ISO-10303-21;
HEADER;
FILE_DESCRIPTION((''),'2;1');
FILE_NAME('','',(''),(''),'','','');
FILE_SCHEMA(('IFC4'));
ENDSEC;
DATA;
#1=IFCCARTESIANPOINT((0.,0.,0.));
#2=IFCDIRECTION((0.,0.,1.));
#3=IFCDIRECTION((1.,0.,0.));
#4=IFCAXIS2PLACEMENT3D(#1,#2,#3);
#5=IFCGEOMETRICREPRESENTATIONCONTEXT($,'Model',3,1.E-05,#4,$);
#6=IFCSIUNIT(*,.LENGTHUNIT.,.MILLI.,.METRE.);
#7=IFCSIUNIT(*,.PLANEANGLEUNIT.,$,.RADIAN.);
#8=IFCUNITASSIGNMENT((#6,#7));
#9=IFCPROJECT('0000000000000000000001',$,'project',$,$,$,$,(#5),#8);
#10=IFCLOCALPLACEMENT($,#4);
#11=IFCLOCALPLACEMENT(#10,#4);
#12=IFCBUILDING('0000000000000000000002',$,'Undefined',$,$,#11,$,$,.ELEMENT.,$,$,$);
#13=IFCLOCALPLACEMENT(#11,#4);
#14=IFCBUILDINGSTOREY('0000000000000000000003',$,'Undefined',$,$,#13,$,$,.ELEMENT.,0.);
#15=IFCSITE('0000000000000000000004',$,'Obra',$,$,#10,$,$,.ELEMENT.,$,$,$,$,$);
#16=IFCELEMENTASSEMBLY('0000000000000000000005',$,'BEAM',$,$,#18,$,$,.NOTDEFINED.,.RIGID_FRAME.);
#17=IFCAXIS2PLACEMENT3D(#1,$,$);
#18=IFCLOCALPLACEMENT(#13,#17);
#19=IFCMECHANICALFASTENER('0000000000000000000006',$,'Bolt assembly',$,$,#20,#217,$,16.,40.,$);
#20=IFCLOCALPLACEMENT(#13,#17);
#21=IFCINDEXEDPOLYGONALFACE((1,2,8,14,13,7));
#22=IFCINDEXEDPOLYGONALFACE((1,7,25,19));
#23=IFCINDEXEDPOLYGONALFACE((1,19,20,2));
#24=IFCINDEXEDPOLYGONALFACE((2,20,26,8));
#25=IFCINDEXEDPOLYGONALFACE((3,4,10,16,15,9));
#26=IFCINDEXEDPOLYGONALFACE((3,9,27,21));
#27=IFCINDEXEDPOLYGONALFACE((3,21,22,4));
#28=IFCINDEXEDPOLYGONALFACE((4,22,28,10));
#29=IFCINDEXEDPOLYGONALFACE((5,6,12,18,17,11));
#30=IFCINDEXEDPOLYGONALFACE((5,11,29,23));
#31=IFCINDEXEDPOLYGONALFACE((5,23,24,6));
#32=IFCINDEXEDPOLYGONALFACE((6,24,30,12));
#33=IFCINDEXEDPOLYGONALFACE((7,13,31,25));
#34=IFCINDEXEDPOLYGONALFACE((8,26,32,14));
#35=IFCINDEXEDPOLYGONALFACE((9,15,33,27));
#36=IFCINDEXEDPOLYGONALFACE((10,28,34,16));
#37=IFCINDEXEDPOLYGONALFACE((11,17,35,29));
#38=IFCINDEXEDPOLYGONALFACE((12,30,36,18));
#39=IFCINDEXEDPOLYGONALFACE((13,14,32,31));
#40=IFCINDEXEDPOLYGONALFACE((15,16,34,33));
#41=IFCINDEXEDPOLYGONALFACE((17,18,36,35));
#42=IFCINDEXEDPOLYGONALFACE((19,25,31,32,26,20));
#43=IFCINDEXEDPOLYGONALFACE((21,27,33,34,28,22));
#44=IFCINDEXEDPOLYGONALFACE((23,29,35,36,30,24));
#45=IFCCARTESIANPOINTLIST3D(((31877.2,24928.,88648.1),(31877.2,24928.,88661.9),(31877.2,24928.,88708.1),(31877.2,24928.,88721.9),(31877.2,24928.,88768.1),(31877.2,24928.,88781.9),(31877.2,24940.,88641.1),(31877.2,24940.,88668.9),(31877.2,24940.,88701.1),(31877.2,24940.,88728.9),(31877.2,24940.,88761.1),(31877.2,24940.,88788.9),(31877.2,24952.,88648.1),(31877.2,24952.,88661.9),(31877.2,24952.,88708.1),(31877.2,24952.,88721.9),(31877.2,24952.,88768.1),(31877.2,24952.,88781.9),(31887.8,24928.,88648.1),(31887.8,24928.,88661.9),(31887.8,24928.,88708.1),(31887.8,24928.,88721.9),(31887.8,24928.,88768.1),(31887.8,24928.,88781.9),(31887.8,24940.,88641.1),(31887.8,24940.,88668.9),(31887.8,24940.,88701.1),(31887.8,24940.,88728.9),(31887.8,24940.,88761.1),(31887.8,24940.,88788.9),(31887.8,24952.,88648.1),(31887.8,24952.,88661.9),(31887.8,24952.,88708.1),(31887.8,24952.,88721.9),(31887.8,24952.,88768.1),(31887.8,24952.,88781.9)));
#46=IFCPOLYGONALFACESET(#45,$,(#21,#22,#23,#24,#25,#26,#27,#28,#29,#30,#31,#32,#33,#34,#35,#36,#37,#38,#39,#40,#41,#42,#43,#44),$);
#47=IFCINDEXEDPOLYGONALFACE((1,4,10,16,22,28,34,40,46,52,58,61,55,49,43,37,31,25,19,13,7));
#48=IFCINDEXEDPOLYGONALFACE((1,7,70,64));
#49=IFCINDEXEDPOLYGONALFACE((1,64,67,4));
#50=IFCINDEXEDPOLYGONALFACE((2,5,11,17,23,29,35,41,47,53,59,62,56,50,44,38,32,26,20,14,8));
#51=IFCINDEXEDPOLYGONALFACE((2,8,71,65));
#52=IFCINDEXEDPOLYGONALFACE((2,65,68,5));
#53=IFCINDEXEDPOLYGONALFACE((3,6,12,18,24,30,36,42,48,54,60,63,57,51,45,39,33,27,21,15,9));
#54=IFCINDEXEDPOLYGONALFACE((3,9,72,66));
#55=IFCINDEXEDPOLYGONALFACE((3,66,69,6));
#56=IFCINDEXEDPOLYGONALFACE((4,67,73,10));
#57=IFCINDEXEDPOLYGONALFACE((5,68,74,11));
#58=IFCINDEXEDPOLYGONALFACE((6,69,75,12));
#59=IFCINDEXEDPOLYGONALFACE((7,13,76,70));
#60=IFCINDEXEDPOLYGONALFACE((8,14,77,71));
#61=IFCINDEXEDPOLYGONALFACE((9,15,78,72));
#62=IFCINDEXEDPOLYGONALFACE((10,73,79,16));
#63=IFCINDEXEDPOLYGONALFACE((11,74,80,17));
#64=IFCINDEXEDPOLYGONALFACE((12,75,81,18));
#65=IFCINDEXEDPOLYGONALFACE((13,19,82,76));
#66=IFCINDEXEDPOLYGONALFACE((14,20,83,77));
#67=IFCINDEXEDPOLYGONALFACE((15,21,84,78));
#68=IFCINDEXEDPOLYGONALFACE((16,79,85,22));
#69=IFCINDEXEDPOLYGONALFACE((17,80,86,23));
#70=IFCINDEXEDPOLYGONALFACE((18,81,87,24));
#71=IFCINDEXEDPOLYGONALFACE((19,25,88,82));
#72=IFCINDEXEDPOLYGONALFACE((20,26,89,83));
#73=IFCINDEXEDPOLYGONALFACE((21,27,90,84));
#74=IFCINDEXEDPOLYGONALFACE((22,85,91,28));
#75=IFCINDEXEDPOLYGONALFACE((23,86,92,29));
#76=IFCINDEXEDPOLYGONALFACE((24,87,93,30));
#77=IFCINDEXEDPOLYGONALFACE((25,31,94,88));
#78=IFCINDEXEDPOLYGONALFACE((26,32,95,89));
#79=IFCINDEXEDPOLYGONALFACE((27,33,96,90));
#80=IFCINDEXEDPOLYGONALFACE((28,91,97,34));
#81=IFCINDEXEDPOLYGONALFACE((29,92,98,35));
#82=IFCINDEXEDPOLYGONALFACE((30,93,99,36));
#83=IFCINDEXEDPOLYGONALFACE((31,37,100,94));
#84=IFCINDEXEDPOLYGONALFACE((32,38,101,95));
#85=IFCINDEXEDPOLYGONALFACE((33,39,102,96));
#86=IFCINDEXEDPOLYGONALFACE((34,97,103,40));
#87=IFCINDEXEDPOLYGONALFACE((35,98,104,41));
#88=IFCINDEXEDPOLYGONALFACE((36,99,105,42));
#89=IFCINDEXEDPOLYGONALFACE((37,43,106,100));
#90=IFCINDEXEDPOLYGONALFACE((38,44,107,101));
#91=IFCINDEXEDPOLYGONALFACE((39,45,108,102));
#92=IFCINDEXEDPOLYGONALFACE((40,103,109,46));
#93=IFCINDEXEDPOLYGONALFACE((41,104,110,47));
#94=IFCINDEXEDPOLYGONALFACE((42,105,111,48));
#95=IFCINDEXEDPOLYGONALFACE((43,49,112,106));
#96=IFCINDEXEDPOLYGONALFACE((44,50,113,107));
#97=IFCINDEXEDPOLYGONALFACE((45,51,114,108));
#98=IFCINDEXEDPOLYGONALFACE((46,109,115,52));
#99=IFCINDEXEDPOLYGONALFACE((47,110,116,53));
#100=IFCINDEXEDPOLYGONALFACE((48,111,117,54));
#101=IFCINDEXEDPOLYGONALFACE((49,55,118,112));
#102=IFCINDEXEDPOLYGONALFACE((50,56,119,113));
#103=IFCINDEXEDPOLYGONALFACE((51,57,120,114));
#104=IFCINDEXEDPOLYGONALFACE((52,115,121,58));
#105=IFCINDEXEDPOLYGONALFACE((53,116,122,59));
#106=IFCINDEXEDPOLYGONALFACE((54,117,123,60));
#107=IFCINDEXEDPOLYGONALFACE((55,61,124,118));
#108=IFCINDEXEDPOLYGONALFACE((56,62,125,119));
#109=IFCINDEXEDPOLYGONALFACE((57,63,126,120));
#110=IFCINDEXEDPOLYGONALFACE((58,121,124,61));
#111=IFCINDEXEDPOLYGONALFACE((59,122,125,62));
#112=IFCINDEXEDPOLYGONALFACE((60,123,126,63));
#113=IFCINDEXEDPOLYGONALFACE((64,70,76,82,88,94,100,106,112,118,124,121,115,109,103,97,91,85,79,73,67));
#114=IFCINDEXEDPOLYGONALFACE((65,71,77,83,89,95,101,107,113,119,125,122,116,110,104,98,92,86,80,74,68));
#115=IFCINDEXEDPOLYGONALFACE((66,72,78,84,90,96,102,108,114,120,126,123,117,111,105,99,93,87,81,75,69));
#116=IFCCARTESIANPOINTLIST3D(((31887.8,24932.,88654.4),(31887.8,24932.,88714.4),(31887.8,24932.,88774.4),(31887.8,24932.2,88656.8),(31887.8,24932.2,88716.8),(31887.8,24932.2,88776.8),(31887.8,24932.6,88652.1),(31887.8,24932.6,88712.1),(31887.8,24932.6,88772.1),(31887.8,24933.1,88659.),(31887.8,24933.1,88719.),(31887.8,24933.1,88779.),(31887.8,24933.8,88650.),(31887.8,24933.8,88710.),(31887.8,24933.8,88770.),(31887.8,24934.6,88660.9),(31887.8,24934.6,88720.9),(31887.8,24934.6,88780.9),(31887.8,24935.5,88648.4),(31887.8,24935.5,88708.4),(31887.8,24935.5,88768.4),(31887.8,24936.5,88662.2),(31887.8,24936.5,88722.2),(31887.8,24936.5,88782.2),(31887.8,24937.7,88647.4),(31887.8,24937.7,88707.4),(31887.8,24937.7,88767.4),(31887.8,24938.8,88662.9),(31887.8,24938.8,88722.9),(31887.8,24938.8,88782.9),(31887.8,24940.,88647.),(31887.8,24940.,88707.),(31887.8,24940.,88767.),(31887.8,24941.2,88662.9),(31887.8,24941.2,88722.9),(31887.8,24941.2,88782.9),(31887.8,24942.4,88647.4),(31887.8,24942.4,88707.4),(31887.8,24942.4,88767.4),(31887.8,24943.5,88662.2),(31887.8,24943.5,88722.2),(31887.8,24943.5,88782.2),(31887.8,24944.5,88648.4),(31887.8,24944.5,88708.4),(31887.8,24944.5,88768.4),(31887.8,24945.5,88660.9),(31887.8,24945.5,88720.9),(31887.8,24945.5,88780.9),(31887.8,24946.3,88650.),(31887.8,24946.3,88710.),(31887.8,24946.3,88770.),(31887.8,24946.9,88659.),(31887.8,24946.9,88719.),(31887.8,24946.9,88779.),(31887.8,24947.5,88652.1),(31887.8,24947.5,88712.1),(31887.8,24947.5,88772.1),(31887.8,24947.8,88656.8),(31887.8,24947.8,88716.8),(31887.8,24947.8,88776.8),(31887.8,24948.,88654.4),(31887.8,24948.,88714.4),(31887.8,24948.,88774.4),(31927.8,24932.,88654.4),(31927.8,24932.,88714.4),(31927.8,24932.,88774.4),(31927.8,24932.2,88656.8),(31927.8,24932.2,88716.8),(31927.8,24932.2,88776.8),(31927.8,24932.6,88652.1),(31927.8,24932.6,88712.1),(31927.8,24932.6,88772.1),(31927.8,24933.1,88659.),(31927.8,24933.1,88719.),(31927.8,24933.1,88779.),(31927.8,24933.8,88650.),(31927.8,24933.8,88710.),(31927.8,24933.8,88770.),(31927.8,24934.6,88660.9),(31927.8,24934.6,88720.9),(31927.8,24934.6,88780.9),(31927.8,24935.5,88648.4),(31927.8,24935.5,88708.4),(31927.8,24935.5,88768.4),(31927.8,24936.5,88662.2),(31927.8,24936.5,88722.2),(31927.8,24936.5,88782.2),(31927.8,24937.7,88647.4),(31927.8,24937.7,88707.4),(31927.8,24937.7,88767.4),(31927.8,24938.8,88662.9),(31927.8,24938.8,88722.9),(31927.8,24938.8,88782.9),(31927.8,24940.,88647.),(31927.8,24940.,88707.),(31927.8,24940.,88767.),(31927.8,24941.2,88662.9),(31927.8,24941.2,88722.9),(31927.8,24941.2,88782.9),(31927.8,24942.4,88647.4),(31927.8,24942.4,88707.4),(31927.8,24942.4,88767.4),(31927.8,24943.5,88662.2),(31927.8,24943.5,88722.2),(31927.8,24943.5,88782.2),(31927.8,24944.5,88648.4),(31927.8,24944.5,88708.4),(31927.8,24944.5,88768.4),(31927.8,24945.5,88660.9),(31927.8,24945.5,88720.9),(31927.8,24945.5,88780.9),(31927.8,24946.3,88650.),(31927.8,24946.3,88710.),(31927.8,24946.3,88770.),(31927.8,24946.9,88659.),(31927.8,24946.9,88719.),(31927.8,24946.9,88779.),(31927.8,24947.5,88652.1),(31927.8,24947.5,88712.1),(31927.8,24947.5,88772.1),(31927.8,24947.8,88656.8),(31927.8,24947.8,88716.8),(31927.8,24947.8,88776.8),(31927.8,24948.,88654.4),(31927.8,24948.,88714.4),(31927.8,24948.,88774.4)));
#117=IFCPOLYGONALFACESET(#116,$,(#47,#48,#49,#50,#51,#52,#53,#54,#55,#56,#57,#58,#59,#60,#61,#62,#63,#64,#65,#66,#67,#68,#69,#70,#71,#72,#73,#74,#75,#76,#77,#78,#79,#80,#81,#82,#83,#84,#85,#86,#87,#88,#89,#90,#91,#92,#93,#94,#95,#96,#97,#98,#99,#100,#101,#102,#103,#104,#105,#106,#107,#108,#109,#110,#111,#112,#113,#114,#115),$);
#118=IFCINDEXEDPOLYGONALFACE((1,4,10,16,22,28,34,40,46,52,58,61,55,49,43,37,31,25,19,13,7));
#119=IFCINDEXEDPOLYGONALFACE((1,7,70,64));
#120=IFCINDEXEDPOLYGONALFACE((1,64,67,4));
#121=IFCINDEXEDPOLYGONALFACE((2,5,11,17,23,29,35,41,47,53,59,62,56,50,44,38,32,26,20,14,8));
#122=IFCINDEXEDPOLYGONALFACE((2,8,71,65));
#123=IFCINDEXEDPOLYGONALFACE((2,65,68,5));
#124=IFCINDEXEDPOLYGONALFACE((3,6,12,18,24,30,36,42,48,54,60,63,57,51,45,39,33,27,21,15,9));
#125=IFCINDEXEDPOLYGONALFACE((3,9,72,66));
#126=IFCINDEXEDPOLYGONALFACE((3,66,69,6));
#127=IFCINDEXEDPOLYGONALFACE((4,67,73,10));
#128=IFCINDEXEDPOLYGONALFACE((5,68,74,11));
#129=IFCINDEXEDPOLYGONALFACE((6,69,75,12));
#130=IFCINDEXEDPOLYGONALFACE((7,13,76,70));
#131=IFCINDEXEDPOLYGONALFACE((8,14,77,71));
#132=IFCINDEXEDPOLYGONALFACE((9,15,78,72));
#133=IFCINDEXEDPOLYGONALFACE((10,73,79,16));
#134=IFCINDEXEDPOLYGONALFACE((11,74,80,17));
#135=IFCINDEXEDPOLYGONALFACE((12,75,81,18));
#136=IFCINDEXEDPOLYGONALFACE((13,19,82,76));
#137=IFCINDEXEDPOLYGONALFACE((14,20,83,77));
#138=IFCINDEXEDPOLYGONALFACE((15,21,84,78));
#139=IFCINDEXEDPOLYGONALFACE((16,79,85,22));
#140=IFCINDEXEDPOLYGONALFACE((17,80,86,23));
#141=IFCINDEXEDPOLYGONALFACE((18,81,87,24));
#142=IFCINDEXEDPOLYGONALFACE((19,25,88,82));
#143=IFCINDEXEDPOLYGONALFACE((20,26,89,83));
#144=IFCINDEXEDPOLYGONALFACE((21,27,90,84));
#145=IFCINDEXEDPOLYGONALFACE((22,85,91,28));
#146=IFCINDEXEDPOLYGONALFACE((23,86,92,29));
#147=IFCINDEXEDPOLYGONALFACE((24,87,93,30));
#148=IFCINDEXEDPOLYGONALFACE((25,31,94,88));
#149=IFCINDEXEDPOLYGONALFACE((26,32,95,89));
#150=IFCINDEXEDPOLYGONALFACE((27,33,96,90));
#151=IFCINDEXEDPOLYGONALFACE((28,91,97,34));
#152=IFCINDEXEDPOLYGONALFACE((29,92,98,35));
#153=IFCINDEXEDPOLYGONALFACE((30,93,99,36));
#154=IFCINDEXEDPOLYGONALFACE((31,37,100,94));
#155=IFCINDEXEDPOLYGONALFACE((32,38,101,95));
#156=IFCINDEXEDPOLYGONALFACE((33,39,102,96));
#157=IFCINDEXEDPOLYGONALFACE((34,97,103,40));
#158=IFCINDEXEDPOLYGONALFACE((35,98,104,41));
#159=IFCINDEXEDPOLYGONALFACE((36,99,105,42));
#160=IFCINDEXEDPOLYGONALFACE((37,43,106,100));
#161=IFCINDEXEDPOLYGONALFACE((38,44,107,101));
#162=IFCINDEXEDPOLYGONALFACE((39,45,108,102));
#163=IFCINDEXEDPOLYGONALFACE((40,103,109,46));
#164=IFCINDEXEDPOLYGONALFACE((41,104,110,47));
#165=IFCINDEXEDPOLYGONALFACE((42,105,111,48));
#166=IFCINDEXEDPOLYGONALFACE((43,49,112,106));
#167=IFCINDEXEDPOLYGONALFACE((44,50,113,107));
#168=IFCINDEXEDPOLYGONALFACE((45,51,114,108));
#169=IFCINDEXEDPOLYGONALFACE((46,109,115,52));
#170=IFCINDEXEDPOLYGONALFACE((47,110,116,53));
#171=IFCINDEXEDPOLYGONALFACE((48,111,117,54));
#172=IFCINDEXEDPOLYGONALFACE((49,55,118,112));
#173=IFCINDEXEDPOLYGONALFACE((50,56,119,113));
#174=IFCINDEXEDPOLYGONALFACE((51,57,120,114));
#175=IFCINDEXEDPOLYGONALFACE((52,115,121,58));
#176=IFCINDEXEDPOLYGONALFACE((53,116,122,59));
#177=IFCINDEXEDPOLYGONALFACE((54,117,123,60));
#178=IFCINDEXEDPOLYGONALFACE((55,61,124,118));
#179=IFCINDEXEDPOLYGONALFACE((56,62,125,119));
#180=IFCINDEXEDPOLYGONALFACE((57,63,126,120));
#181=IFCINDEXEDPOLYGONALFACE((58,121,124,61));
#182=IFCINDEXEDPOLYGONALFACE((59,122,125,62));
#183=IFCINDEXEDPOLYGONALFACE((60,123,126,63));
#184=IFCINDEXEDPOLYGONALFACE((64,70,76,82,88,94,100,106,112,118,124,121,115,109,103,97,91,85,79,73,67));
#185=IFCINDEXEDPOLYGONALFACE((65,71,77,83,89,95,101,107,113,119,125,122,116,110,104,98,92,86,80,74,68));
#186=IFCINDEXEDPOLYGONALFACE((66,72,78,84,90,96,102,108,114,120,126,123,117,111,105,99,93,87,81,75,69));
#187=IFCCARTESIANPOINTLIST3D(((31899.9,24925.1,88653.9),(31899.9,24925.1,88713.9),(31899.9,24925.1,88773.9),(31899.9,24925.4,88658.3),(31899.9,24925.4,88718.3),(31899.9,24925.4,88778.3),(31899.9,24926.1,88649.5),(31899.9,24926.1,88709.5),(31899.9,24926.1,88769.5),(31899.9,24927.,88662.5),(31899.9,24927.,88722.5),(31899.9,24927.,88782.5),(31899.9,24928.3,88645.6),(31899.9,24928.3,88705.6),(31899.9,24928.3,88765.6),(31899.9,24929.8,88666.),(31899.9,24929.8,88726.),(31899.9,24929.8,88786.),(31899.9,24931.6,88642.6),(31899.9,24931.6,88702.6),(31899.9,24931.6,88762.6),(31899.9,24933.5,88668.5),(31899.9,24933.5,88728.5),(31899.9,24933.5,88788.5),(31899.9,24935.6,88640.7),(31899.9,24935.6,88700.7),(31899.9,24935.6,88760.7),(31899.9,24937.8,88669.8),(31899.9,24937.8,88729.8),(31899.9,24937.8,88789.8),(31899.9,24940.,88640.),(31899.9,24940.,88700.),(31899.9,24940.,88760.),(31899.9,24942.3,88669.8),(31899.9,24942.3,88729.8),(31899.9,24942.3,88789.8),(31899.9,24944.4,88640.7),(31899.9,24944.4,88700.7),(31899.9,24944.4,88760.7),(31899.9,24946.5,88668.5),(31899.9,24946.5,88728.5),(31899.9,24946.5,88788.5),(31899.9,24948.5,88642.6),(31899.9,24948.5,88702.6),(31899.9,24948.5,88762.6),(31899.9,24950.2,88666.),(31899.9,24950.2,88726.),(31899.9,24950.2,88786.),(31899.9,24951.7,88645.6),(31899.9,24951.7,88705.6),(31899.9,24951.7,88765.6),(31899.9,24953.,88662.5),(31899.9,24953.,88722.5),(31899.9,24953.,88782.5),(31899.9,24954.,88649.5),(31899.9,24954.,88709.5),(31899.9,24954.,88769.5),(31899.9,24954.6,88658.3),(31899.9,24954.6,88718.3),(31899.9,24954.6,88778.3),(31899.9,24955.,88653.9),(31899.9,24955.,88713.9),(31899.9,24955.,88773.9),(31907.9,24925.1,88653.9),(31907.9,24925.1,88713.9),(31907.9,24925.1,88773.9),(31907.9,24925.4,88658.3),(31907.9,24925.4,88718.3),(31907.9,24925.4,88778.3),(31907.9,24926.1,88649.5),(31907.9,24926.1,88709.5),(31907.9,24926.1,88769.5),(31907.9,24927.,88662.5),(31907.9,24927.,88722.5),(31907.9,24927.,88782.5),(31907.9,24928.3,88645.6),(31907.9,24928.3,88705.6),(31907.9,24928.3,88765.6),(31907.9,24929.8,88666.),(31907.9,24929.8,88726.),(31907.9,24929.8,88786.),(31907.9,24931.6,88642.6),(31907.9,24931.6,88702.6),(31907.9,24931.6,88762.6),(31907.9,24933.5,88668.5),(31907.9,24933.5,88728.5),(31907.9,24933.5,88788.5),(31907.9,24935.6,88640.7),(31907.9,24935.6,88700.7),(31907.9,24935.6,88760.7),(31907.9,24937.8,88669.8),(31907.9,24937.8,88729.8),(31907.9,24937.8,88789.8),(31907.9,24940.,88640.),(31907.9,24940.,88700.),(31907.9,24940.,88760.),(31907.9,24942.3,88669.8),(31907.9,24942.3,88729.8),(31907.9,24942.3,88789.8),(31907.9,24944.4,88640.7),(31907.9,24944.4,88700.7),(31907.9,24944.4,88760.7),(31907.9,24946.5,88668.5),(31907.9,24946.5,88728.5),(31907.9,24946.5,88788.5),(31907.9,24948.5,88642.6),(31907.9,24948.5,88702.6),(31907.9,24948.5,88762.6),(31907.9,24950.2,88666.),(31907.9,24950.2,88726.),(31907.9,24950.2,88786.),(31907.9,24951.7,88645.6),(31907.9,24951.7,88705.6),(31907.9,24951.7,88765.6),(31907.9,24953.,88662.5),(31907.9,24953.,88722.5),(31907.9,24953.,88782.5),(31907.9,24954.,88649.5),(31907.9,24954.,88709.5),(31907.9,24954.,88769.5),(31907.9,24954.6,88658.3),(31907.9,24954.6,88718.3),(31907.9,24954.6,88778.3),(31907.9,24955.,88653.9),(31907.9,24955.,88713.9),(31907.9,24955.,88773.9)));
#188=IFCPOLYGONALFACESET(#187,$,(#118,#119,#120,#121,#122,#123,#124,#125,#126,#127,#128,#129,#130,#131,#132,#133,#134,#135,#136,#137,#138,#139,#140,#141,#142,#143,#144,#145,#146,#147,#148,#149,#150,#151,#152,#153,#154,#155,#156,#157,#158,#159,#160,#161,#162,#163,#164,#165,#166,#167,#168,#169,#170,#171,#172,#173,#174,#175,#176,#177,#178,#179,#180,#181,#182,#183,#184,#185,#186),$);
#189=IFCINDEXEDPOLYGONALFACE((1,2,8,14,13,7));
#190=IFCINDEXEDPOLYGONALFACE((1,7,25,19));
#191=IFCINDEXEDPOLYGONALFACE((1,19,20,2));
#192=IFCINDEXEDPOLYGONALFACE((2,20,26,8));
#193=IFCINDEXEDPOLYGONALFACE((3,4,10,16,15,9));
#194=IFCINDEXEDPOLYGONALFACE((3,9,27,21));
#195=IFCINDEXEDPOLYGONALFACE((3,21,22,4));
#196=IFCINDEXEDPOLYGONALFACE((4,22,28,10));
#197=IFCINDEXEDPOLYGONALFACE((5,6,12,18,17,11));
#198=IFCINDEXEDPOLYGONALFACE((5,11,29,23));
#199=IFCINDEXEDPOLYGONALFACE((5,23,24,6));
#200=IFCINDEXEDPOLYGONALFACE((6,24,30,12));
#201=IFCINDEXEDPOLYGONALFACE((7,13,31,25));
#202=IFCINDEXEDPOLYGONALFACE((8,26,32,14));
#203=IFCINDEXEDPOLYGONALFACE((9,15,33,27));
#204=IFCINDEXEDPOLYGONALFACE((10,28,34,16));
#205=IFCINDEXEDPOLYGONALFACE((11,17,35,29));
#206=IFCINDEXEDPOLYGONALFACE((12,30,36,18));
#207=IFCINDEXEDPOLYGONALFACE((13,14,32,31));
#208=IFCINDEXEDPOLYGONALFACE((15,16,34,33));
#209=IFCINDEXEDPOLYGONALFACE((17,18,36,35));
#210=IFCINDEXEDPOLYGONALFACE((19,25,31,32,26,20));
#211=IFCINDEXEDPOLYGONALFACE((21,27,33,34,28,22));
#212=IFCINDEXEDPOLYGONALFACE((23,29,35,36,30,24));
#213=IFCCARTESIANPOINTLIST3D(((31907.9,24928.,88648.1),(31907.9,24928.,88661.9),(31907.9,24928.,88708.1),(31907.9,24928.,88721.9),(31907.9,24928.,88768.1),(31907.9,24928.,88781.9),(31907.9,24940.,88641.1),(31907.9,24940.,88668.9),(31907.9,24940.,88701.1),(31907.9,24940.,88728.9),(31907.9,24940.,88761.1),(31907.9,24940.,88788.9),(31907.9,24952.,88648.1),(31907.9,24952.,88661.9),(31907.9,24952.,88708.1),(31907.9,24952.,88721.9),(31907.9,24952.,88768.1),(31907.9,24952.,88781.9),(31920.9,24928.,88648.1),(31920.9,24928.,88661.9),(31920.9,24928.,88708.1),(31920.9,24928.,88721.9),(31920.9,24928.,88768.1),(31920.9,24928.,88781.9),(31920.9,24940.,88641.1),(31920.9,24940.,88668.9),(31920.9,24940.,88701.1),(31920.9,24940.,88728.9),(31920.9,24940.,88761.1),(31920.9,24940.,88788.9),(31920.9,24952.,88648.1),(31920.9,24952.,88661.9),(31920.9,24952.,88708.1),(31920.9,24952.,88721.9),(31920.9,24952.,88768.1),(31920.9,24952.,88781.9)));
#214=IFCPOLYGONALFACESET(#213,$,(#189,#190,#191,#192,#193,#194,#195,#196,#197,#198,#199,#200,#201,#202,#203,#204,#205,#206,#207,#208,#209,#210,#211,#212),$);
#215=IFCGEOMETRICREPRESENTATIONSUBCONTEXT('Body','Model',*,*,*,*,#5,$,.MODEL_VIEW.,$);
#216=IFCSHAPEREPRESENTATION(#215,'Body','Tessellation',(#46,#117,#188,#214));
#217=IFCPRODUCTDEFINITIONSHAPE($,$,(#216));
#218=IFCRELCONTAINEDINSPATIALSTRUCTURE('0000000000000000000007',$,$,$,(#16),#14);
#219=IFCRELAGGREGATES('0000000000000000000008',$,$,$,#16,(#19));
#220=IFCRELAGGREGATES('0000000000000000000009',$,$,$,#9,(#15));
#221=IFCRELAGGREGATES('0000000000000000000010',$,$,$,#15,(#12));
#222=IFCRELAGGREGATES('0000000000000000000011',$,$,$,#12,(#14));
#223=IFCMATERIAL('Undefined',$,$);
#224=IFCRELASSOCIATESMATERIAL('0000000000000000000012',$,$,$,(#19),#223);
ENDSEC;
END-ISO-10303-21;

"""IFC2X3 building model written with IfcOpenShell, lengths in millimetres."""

from ifc_helpers import new_model, si_unit, frame, origin_with_axes, origin_2d_with_axis, place, context, subcontext, project, spatial, polyline, circle, outline, extrude, source, transform, mapped, material, element, aggregate, save


model = new_model("IFC2X3")

# Units and contexts
model_context = context("Model", 3, precision=1e-05, world=origin_with_axes())
body_context = subcontext(model_context, "Body", "Model", "MODEL_VIEW")
ifc_project = project(units=[si_unit("LENGTHUNIT", "METRE", prefix="MILLI"), si_unit("PLANEANGLEUNIT", "RADIAN")], contexts=[model_context])

# Site, building, storey
site_placement = place(None, origin_with_axes())
site = spatial("IfcSite", under=ifc_project, at=site_placement, Name="Obra", CompositionType="ELEMENT")
building_placement = place(site_placement, origin_with_axes())
building = spatial("IfcBuilding", under=site, at=building_placement, Name="Undefined", CompositionType="ELEMENT")
storey_placement = place(building_placement, origin_with_axes())
storey = spatial("IfcBuildingStorey", under=building, at=storey_placement, Name="Undefined", CompositionType="ELEMENT", Elevation=0.0)

# Shared definitions
ifc_material_1 = material(Name="Undefined")

# Element assembly
assembly_1_placement = place(storey_placement, origin_with_axes())
assembly_1 = element("IfcElementAssembly", 1, at=assembly_1_placement, inside=storey, Name="BEAM", AssemblyPlace="NOTDEFINED", PredefinedType="RIGID_FRAME")

# Mechanical fastener
shared_shape_1 = source(origin_with_axes(), body_context, "Body", "SweptSolid", [
    extrude(outline(polyline([(13.9, 0.0), (6.9, 12.0), (-6.9, 12.0), (-13.9, 0.0), (-6.9, -12.0), (6.9, -12.0), (13.9, 0.0)])), frame((0.0, -19.7, 0.0), z_axis=(0.0, 1.0, 0.0), x_axis=(1.0, 0.0, 0.0)), (0.0, 0.0, 1.0), 10.6),
    extrude(circle(Radius=8.0, at=origin_2d_with_axis()), frame((0.0, -9.1, 0.0), z_axis=(0.0, 1.0, 0.0), x_axis=(1.0, 0.0, 0.0)), (0.0, 0.0, 1.0), 40.0),
    extrude(circle(Radius=15.0, at=origin_2d_with_axis()), frame((0.0, 3.0, 0.0), z_axis=(0.0, 1.0, 0.0), x_axis=(1.0, 0.0, 0.0)), (0.0, 0.0, 1.0), 8.0),
    extrude(outline(polyline([(13.9, 0.0), (6.9, 12.0), (-6.9, 12.0), (-13.9, 0.0), (-6.9, -12.0), (6.9, -12.0), (13.9, 0.0)])), frame((0.0, 11.0, 0.0), z_axis=(0.0, 1.0, 0.0), x_axis=(1.0, 0.0, 0.0)), (0.0, 0.0, 1.0), 13.0),
])
mechanical_fastener_1_placement = place(assembly_1_placement, frame((31896.9, 24990.0, 88835.0), z_axis=(0.000002, -1.0, 0.0), x_axis=(0.0, 0.0, -1.0)))
mechanical_fastener_1 = element("IfcMechanicalFastener", 2, at=mechanical_fastener_1_placement, material=ifc_material_1, Name="Bolt assembly", NominalDiameter=16.0, NominalLength=40.0, context=body_context, shape_type="MappedRepresentation", body=[
    mapped(shared_shape_1, transform((60.0, 0.0, 50.0))),
    mapped(shared_shape_1, transform((120.0, 0.0, 50.0))),
    mapped(shared_shape_1, transform((180.0, 0.0, 50.0))),
])
aggregate(assembly_1, [mechanical_fastener_1])

save(model, "model.ifc")
